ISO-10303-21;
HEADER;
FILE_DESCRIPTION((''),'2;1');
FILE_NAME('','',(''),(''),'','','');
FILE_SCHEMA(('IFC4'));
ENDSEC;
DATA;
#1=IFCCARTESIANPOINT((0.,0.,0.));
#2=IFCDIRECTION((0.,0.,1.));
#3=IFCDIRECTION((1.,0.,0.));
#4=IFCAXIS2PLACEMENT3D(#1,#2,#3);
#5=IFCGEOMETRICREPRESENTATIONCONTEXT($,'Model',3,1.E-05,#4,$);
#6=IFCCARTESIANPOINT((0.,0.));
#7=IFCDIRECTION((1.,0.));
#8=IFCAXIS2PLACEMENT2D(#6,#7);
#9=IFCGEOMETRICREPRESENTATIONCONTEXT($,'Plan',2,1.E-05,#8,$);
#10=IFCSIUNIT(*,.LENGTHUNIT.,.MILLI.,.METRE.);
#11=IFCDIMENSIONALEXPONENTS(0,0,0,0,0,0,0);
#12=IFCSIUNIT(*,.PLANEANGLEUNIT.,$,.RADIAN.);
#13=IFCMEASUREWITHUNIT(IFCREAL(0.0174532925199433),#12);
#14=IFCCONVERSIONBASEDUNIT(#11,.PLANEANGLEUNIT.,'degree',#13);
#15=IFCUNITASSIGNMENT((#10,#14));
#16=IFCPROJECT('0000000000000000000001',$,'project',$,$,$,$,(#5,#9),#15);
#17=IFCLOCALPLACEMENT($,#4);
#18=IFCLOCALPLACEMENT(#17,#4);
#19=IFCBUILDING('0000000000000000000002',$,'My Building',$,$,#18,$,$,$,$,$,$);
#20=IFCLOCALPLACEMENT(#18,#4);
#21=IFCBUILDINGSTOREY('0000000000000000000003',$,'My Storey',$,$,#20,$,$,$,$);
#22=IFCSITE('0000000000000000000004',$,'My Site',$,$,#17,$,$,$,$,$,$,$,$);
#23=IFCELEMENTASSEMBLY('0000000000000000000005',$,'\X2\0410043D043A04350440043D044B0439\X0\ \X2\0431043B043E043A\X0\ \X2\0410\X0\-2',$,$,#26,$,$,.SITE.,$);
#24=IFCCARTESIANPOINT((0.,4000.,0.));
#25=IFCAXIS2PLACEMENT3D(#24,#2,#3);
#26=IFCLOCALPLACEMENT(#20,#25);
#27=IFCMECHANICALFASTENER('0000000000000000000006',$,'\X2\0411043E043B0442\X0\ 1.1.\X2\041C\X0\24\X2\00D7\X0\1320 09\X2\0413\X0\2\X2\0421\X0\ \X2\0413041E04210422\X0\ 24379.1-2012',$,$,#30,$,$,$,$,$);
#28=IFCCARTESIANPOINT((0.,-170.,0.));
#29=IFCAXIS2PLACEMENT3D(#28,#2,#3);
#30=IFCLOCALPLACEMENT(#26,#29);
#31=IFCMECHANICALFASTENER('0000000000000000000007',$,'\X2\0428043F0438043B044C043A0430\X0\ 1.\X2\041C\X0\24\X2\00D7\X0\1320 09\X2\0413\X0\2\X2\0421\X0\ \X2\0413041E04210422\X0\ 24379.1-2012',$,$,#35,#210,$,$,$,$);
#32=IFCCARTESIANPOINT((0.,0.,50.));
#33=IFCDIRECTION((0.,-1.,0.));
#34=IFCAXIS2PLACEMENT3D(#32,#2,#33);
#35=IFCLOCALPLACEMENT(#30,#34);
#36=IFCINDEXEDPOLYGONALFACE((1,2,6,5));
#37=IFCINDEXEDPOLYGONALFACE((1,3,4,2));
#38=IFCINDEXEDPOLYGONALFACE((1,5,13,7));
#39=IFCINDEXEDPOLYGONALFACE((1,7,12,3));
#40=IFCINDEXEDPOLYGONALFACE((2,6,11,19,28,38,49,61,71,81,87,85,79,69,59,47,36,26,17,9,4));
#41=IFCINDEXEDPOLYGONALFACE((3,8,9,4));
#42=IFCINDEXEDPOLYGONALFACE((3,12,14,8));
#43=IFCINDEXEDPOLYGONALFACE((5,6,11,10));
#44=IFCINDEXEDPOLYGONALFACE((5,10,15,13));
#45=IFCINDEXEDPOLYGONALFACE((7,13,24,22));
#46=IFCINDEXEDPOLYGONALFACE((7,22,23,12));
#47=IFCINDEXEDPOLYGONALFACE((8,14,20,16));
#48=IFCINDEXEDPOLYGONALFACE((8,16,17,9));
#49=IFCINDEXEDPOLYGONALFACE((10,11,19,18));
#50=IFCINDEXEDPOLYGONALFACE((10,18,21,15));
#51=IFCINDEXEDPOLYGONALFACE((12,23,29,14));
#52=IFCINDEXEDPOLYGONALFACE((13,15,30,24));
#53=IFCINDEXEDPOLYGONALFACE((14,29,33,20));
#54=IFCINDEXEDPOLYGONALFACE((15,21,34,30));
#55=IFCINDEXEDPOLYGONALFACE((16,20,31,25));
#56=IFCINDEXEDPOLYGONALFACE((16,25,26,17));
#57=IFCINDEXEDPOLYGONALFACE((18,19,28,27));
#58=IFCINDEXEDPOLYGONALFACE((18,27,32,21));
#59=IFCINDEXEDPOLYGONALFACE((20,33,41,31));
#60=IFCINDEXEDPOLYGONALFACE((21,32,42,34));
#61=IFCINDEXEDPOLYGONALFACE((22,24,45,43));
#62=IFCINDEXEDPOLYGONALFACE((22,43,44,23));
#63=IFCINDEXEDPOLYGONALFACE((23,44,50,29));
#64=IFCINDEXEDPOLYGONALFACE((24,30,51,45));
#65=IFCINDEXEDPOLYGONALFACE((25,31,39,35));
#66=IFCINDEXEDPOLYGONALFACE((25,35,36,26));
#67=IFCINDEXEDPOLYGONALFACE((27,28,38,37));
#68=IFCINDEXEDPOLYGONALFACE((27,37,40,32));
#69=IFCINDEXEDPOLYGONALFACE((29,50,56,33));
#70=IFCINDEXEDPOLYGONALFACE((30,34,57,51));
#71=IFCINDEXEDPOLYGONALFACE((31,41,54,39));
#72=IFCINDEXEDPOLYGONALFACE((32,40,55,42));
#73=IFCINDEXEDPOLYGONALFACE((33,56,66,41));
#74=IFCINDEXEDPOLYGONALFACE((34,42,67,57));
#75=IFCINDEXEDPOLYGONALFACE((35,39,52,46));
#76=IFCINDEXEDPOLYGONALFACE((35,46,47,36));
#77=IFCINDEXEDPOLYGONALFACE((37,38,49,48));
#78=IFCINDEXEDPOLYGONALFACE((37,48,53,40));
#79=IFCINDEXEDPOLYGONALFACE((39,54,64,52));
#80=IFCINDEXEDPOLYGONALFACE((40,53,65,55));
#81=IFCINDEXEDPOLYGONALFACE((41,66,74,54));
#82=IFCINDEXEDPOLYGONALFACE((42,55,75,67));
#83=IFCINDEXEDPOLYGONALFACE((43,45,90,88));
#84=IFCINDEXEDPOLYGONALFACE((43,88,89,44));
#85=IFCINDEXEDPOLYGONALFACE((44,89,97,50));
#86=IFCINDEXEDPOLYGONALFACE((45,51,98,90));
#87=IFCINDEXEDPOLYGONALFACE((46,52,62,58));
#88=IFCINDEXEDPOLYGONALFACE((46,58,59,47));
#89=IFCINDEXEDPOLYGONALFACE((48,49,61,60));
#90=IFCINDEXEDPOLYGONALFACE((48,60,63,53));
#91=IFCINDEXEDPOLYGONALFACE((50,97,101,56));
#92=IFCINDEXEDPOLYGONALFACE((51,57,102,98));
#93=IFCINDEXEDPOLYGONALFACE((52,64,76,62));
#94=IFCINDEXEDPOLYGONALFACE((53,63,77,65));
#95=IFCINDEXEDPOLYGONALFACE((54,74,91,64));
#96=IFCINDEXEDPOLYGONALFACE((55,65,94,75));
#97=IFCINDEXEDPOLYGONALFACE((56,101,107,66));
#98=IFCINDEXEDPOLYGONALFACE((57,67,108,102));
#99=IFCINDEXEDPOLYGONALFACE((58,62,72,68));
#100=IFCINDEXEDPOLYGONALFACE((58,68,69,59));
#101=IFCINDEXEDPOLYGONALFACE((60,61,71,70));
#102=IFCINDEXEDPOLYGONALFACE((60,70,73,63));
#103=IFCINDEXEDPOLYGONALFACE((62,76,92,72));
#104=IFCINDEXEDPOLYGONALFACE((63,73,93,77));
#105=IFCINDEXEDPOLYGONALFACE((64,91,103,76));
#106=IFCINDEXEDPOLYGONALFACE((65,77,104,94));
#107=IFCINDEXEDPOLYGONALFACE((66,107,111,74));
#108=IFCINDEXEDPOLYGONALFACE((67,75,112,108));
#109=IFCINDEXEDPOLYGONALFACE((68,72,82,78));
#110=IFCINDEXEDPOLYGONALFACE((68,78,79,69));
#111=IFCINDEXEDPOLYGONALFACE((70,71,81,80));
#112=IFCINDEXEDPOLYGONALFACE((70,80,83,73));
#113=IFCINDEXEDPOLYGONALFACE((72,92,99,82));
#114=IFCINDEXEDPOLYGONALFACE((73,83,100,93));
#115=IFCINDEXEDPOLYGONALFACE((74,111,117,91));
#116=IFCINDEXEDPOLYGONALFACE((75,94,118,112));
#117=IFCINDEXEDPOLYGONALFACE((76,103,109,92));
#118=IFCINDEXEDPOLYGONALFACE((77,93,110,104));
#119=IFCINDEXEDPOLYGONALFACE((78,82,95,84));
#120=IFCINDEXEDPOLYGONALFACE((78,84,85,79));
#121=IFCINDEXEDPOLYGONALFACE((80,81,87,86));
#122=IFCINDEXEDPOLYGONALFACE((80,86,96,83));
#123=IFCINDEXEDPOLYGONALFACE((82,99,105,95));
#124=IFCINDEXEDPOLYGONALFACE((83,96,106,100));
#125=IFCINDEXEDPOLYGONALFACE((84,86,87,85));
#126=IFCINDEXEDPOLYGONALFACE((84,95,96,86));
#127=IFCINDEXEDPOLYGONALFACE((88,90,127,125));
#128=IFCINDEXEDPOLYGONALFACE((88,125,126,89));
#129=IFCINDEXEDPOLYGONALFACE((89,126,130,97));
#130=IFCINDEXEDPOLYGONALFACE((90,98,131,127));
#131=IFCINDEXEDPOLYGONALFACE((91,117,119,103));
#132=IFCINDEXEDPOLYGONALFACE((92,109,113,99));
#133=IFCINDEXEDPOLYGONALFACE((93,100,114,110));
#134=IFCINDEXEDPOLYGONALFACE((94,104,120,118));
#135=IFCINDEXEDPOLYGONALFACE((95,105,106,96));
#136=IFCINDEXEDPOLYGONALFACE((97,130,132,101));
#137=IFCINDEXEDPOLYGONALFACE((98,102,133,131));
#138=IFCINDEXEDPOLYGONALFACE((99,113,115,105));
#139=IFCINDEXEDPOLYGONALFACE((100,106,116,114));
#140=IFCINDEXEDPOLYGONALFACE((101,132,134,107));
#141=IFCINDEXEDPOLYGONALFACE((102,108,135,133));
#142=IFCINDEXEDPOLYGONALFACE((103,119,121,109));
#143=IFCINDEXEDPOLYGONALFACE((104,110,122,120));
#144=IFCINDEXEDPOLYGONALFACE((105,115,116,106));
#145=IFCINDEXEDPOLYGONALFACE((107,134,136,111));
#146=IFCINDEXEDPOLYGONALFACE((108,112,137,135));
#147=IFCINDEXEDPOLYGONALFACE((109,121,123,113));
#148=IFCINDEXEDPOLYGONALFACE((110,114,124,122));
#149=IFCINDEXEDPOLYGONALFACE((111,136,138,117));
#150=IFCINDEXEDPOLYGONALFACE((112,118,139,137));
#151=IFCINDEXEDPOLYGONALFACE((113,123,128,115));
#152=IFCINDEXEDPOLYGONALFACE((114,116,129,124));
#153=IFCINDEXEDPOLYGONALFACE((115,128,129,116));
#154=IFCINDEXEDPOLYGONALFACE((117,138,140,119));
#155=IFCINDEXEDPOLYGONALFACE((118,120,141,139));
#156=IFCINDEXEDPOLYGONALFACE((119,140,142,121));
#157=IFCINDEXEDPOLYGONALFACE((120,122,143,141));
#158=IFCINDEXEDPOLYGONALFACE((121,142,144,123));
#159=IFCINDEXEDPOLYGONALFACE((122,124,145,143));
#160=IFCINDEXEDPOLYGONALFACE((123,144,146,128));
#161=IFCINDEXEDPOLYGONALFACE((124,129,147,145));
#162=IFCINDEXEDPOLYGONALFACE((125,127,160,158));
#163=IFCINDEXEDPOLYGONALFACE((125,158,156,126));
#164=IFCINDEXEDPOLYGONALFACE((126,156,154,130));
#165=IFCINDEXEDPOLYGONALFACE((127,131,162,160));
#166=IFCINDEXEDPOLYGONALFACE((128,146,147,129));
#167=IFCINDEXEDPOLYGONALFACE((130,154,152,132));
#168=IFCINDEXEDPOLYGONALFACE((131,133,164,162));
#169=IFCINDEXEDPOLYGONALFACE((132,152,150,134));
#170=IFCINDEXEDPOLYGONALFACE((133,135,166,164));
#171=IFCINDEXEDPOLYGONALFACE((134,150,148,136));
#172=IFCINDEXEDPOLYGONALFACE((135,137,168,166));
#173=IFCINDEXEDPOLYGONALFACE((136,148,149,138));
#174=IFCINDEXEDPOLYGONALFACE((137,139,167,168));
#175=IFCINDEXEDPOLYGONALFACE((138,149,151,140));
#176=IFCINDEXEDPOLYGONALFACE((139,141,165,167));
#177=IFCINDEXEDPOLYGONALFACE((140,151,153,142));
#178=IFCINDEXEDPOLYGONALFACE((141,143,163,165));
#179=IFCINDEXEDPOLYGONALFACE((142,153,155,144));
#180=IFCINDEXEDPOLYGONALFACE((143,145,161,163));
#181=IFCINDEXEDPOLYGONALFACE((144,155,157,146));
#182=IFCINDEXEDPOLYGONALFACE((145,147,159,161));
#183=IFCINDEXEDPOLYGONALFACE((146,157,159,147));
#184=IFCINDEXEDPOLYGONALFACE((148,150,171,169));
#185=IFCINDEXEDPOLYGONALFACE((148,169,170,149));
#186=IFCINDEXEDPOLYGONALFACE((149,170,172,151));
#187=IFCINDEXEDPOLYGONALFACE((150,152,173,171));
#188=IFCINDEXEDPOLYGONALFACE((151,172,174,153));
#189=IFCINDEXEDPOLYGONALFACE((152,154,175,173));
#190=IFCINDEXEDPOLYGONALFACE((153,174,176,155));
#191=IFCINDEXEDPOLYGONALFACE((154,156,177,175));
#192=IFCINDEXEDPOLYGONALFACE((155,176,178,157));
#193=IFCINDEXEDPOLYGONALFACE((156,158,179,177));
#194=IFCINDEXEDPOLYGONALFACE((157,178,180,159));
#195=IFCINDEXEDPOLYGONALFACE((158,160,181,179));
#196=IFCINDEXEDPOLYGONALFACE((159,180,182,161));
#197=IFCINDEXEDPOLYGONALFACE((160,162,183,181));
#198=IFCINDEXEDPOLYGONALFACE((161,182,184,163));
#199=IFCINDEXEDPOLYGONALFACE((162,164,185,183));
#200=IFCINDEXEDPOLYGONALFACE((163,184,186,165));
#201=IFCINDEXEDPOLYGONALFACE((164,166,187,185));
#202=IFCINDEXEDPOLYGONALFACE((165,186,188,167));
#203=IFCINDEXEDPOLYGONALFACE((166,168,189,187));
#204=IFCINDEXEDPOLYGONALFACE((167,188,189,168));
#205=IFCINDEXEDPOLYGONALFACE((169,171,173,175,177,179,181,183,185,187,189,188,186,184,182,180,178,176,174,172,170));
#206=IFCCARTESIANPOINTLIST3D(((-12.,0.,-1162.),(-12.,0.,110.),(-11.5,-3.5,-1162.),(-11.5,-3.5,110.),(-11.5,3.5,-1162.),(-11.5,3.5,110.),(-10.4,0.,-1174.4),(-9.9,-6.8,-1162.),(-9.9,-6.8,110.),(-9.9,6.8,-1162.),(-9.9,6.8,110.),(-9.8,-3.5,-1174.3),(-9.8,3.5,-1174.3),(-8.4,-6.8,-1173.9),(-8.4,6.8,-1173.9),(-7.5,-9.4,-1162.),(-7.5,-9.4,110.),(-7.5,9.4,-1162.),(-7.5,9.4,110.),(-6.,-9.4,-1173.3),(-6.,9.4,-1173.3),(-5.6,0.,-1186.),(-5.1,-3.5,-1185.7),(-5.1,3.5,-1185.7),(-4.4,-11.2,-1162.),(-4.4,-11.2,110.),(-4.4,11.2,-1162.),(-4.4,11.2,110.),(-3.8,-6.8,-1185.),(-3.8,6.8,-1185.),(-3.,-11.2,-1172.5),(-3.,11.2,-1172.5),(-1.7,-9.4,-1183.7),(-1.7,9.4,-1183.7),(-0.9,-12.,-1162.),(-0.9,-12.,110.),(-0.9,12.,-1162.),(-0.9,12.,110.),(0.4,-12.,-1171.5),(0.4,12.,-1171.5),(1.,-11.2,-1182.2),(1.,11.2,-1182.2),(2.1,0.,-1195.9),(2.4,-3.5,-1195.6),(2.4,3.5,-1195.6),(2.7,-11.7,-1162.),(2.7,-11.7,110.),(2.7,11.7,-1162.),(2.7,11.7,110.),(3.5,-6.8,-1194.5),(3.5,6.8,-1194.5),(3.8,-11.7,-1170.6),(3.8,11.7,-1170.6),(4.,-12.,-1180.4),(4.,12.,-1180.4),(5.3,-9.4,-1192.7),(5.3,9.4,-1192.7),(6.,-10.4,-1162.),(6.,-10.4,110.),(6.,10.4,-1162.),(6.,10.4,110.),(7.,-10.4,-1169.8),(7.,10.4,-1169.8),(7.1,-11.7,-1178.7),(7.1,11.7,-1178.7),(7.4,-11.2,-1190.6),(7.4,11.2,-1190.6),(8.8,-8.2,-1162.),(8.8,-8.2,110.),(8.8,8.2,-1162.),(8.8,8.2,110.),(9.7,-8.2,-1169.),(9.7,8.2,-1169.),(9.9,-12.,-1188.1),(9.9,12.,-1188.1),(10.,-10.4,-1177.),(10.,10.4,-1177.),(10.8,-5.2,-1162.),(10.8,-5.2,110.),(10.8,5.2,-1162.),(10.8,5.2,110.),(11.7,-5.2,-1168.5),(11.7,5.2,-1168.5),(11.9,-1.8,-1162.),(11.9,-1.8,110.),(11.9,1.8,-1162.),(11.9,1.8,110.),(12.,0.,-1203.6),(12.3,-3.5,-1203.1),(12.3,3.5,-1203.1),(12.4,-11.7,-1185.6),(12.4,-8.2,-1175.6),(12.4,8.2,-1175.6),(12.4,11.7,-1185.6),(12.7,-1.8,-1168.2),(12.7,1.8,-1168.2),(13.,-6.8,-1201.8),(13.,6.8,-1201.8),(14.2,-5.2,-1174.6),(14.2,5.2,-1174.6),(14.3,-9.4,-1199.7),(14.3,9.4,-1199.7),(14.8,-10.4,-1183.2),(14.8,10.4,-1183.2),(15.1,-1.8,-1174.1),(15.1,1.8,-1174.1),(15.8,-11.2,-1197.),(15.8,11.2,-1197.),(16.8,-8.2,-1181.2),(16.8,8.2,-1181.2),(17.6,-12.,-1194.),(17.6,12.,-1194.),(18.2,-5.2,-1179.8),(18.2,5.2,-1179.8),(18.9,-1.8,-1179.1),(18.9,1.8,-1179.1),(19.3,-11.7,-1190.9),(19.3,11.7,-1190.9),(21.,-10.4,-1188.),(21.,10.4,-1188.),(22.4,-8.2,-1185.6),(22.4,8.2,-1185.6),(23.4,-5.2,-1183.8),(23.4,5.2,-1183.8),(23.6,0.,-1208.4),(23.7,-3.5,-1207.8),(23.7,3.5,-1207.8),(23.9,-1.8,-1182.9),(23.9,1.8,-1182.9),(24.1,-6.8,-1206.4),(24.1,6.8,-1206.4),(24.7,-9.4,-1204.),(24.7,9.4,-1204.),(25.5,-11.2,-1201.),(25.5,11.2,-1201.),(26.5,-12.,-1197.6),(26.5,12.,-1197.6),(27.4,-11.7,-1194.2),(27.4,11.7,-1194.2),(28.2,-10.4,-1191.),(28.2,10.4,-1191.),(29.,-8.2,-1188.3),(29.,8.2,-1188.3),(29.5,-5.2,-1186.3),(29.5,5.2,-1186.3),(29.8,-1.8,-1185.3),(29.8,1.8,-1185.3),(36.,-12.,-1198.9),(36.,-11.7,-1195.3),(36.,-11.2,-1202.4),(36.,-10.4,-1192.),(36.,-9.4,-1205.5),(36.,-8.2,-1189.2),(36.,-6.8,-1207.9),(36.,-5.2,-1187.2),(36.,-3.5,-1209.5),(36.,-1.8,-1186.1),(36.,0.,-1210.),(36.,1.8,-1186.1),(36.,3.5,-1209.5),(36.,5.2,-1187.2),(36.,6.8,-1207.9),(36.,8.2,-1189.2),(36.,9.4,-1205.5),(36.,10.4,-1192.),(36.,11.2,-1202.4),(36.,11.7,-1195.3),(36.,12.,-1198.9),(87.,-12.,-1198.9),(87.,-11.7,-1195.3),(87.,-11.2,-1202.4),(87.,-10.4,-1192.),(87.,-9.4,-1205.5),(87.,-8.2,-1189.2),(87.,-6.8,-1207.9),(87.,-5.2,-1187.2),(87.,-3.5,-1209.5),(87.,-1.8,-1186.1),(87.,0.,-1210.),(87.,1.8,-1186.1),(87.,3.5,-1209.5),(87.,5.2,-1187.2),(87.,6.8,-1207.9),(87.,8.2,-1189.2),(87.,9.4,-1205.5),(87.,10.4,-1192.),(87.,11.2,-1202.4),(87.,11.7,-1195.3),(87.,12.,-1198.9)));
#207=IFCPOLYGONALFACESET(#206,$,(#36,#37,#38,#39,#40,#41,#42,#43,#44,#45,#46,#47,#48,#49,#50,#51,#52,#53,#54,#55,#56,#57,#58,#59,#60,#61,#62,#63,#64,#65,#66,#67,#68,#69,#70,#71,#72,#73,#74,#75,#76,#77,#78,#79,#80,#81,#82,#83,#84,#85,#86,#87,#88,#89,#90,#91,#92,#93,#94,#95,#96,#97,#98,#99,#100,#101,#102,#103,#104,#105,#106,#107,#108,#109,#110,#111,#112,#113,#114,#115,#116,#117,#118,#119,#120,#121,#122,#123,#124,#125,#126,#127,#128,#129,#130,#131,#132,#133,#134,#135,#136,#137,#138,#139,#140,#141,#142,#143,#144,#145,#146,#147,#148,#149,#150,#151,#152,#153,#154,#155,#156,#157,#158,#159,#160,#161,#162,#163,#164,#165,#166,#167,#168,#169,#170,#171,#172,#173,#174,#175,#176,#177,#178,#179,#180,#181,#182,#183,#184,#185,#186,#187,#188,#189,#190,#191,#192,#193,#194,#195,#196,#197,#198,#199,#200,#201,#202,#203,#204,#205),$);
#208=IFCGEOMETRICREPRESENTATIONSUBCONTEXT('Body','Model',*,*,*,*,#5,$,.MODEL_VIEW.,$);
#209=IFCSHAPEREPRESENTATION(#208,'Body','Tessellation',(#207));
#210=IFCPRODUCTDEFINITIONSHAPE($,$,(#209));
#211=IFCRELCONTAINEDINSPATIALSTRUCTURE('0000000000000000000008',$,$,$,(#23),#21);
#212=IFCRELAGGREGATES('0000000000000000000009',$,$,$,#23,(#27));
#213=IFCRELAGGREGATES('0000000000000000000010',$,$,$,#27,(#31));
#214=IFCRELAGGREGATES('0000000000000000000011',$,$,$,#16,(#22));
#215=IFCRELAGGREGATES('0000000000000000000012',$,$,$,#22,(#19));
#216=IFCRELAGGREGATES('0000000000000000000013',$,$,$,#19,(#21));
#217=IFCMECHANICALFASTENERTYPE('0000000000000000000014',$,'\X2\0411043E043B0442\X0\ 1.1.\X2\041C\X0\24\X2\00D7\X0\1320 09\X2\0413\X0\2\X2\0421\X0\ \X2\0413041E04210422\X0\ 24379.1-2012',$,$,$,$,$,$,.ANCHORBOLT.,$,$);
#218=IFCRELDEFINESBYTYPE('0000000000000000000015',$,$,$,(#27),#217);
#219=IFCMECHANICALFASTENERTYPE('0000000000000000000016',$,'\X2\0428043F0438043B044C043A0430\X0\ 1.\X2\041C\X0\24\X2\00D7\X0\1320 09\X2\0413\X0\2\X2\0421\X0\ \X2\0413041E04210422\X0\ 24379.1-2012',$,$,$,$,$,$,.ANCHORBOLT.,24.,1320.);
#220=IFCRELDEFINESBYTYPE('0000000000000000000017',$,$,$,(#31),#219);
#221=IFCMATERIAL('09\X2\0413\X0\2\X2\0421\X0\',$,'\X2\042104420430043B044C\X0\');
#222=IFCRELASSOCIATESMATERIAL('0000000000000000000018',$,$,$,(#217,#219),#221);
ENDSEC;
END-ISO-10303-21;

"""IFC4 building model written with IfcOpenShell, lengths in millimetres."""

from ifc_helpers import new_model, entity, si_unit, converted_unit, frame, origin_with_axes, origin_2d_with_axis, place, context, subcontext, project, spatial, source, transform, mapped, material, type_object, type_shapes, element, aggregate, save


model = new_model("IFC4")

# Units and contexts
model_context = context("Model", 3, precision=1e-05, world=origin_with_axes())
plan_context = context("Plan", 2, precision=1e-05, world=origin_2d_with_axis())
body_context = subcontext(model_context, "Body", "Model", "MODEL_VIEW")
ifc_project = project(units=[si_unit("LENGTHUNIT", "METRE", prefix="MILLI"), converted_unit("PLANEANGLEUNIT", "degree", entity("IfcReal", 0.0174532925199433), si_unit("PLANEANGLEUNIT", "RADIAN"), dimensions=[0, 0, 0, 0, 0, 0, 0])], contexts=[model_context, plan_context])

# Site, building, storey
site_placement = place(None, origin_with_axes())
site = spatial("IfcSite", under=ifc_project, at=site_placement, Name="My Site")
building_placement = place(site_placement, origin_with_axes())
building = spatial("IfcBuilding", under=site, at=building_placement, Name="My Building")
storey_placement = place(building_placement, origin_with_axes())
storey = spatial("IfcBuildingStorey", under=building, at=storey_placement, Name="My Storey")

# Shared definitions
placement = place(storey_placement, frame((0.0, 4000.0, 0.0), z_axis=(0.0, 0.0, 1.0), x_axis=(1.0, 0.0, 0.0)))

# Element assembly, mechanical fasteners
assembly_1 = element("IfcElementAssembly", 1, at=placement, inside=storey, Name="Анкерный блок А-2", AssemblyPlace="SITE")
ifc_material_1 = material(Name="09Г2С", Category="Сталь")
mechanical_fastener_type_1 = type_object("IfcMechanicalFastenerType", Name="Болт 1.1.М24×1320 09Г2С ГОСТ 24379.1-2012", PredefinedType="ANCHORBOLT", material=ifc_material_1)
mechanical_fastener_1_placement = place(placement, frame((0.0, -170.0, 0.0), z_axis=(0.0, 0.0, 1.0), x_axis=(1.0, 0.0, 0.0)))
mechanical_fastener_1 = element("IfcMechanicalFastener", 2, at=mechanical_fastener_1_placement, type_object=mechanical_fastener_type_1, Name="Болт 1.1.М24×1320 09Г2С ГОСТ 24379.1-2012")
mechanical_fastener_type_2 = type_object("IfcMechanicalFastenerType", Name="Шпилька 1.М24×1320 09Г2С ГОСТ 24379.1-2012", NominalDiameter=24.0, NominalLength=1320.0, PredefinedType="ANCHORBOLT", material=ifc_material_1)
shared_shape_1 = source(frame((0.0, 0.0, 110.0), z_axis=(0.0, 0.0, 1.0), x_axis=(1.0, 0.0, 0.0)), body_context, "Body", "AdvancedSweptSolid", [
    entity("IfcSweptDiskSolid", entity("IfcIndexedPolyCurve", entity("IfcCartesianPointList3D", [[0.0, 0.0, 0.0], [0.0, 0.0, -1272.0], [10.5, 0.0, -1297.5], [36.0, 0.0, -1308.0], [87.0, 0.0, -1308.0]]), [entity("IfcLineIndex", [1, 2]), entity("IfcArcIndex", [2, 3, 4]), entity("IfcLineIndex", [4, 5])]), 12.0),
])
type_shapes(mechanical_fastener_type_2, [shared_shape_1])
mechanical_fastener_2_placement = place(mechanical_fastener_1_placement, frame((0.0, 0.0, 50.0), z_axis=(0.0, 0.0, 1.0), x_axis=(0.0, -1.0, 0.0)))
mechanical_fastener_2 = element("IfcMechanicalFastener", 3, at=mechanical_fastener_2_placement, type_object=mechanical_fastener_type_2, Name="Шпилька 1.М24×1320 09Г2С ГОСТ 24379.1-2012", context=body_context, shape_type="MappedRepresentation", body=[
    mapped(shared_shape_1, transform((0.0, 0.0, 0.0), x_axis=(1.0, 0.0, 0.0), y_axis=(0.0, 1.0, 0.0), z_axis=(0.0, 0.0, 1.0), scale=1.0)),
])
aggregate(assembly_1, [mechanical_fastener_1])

aggregate(mechanical_fastener_1, [mechanical_fastener_2])

save(model, "model.ifc")
